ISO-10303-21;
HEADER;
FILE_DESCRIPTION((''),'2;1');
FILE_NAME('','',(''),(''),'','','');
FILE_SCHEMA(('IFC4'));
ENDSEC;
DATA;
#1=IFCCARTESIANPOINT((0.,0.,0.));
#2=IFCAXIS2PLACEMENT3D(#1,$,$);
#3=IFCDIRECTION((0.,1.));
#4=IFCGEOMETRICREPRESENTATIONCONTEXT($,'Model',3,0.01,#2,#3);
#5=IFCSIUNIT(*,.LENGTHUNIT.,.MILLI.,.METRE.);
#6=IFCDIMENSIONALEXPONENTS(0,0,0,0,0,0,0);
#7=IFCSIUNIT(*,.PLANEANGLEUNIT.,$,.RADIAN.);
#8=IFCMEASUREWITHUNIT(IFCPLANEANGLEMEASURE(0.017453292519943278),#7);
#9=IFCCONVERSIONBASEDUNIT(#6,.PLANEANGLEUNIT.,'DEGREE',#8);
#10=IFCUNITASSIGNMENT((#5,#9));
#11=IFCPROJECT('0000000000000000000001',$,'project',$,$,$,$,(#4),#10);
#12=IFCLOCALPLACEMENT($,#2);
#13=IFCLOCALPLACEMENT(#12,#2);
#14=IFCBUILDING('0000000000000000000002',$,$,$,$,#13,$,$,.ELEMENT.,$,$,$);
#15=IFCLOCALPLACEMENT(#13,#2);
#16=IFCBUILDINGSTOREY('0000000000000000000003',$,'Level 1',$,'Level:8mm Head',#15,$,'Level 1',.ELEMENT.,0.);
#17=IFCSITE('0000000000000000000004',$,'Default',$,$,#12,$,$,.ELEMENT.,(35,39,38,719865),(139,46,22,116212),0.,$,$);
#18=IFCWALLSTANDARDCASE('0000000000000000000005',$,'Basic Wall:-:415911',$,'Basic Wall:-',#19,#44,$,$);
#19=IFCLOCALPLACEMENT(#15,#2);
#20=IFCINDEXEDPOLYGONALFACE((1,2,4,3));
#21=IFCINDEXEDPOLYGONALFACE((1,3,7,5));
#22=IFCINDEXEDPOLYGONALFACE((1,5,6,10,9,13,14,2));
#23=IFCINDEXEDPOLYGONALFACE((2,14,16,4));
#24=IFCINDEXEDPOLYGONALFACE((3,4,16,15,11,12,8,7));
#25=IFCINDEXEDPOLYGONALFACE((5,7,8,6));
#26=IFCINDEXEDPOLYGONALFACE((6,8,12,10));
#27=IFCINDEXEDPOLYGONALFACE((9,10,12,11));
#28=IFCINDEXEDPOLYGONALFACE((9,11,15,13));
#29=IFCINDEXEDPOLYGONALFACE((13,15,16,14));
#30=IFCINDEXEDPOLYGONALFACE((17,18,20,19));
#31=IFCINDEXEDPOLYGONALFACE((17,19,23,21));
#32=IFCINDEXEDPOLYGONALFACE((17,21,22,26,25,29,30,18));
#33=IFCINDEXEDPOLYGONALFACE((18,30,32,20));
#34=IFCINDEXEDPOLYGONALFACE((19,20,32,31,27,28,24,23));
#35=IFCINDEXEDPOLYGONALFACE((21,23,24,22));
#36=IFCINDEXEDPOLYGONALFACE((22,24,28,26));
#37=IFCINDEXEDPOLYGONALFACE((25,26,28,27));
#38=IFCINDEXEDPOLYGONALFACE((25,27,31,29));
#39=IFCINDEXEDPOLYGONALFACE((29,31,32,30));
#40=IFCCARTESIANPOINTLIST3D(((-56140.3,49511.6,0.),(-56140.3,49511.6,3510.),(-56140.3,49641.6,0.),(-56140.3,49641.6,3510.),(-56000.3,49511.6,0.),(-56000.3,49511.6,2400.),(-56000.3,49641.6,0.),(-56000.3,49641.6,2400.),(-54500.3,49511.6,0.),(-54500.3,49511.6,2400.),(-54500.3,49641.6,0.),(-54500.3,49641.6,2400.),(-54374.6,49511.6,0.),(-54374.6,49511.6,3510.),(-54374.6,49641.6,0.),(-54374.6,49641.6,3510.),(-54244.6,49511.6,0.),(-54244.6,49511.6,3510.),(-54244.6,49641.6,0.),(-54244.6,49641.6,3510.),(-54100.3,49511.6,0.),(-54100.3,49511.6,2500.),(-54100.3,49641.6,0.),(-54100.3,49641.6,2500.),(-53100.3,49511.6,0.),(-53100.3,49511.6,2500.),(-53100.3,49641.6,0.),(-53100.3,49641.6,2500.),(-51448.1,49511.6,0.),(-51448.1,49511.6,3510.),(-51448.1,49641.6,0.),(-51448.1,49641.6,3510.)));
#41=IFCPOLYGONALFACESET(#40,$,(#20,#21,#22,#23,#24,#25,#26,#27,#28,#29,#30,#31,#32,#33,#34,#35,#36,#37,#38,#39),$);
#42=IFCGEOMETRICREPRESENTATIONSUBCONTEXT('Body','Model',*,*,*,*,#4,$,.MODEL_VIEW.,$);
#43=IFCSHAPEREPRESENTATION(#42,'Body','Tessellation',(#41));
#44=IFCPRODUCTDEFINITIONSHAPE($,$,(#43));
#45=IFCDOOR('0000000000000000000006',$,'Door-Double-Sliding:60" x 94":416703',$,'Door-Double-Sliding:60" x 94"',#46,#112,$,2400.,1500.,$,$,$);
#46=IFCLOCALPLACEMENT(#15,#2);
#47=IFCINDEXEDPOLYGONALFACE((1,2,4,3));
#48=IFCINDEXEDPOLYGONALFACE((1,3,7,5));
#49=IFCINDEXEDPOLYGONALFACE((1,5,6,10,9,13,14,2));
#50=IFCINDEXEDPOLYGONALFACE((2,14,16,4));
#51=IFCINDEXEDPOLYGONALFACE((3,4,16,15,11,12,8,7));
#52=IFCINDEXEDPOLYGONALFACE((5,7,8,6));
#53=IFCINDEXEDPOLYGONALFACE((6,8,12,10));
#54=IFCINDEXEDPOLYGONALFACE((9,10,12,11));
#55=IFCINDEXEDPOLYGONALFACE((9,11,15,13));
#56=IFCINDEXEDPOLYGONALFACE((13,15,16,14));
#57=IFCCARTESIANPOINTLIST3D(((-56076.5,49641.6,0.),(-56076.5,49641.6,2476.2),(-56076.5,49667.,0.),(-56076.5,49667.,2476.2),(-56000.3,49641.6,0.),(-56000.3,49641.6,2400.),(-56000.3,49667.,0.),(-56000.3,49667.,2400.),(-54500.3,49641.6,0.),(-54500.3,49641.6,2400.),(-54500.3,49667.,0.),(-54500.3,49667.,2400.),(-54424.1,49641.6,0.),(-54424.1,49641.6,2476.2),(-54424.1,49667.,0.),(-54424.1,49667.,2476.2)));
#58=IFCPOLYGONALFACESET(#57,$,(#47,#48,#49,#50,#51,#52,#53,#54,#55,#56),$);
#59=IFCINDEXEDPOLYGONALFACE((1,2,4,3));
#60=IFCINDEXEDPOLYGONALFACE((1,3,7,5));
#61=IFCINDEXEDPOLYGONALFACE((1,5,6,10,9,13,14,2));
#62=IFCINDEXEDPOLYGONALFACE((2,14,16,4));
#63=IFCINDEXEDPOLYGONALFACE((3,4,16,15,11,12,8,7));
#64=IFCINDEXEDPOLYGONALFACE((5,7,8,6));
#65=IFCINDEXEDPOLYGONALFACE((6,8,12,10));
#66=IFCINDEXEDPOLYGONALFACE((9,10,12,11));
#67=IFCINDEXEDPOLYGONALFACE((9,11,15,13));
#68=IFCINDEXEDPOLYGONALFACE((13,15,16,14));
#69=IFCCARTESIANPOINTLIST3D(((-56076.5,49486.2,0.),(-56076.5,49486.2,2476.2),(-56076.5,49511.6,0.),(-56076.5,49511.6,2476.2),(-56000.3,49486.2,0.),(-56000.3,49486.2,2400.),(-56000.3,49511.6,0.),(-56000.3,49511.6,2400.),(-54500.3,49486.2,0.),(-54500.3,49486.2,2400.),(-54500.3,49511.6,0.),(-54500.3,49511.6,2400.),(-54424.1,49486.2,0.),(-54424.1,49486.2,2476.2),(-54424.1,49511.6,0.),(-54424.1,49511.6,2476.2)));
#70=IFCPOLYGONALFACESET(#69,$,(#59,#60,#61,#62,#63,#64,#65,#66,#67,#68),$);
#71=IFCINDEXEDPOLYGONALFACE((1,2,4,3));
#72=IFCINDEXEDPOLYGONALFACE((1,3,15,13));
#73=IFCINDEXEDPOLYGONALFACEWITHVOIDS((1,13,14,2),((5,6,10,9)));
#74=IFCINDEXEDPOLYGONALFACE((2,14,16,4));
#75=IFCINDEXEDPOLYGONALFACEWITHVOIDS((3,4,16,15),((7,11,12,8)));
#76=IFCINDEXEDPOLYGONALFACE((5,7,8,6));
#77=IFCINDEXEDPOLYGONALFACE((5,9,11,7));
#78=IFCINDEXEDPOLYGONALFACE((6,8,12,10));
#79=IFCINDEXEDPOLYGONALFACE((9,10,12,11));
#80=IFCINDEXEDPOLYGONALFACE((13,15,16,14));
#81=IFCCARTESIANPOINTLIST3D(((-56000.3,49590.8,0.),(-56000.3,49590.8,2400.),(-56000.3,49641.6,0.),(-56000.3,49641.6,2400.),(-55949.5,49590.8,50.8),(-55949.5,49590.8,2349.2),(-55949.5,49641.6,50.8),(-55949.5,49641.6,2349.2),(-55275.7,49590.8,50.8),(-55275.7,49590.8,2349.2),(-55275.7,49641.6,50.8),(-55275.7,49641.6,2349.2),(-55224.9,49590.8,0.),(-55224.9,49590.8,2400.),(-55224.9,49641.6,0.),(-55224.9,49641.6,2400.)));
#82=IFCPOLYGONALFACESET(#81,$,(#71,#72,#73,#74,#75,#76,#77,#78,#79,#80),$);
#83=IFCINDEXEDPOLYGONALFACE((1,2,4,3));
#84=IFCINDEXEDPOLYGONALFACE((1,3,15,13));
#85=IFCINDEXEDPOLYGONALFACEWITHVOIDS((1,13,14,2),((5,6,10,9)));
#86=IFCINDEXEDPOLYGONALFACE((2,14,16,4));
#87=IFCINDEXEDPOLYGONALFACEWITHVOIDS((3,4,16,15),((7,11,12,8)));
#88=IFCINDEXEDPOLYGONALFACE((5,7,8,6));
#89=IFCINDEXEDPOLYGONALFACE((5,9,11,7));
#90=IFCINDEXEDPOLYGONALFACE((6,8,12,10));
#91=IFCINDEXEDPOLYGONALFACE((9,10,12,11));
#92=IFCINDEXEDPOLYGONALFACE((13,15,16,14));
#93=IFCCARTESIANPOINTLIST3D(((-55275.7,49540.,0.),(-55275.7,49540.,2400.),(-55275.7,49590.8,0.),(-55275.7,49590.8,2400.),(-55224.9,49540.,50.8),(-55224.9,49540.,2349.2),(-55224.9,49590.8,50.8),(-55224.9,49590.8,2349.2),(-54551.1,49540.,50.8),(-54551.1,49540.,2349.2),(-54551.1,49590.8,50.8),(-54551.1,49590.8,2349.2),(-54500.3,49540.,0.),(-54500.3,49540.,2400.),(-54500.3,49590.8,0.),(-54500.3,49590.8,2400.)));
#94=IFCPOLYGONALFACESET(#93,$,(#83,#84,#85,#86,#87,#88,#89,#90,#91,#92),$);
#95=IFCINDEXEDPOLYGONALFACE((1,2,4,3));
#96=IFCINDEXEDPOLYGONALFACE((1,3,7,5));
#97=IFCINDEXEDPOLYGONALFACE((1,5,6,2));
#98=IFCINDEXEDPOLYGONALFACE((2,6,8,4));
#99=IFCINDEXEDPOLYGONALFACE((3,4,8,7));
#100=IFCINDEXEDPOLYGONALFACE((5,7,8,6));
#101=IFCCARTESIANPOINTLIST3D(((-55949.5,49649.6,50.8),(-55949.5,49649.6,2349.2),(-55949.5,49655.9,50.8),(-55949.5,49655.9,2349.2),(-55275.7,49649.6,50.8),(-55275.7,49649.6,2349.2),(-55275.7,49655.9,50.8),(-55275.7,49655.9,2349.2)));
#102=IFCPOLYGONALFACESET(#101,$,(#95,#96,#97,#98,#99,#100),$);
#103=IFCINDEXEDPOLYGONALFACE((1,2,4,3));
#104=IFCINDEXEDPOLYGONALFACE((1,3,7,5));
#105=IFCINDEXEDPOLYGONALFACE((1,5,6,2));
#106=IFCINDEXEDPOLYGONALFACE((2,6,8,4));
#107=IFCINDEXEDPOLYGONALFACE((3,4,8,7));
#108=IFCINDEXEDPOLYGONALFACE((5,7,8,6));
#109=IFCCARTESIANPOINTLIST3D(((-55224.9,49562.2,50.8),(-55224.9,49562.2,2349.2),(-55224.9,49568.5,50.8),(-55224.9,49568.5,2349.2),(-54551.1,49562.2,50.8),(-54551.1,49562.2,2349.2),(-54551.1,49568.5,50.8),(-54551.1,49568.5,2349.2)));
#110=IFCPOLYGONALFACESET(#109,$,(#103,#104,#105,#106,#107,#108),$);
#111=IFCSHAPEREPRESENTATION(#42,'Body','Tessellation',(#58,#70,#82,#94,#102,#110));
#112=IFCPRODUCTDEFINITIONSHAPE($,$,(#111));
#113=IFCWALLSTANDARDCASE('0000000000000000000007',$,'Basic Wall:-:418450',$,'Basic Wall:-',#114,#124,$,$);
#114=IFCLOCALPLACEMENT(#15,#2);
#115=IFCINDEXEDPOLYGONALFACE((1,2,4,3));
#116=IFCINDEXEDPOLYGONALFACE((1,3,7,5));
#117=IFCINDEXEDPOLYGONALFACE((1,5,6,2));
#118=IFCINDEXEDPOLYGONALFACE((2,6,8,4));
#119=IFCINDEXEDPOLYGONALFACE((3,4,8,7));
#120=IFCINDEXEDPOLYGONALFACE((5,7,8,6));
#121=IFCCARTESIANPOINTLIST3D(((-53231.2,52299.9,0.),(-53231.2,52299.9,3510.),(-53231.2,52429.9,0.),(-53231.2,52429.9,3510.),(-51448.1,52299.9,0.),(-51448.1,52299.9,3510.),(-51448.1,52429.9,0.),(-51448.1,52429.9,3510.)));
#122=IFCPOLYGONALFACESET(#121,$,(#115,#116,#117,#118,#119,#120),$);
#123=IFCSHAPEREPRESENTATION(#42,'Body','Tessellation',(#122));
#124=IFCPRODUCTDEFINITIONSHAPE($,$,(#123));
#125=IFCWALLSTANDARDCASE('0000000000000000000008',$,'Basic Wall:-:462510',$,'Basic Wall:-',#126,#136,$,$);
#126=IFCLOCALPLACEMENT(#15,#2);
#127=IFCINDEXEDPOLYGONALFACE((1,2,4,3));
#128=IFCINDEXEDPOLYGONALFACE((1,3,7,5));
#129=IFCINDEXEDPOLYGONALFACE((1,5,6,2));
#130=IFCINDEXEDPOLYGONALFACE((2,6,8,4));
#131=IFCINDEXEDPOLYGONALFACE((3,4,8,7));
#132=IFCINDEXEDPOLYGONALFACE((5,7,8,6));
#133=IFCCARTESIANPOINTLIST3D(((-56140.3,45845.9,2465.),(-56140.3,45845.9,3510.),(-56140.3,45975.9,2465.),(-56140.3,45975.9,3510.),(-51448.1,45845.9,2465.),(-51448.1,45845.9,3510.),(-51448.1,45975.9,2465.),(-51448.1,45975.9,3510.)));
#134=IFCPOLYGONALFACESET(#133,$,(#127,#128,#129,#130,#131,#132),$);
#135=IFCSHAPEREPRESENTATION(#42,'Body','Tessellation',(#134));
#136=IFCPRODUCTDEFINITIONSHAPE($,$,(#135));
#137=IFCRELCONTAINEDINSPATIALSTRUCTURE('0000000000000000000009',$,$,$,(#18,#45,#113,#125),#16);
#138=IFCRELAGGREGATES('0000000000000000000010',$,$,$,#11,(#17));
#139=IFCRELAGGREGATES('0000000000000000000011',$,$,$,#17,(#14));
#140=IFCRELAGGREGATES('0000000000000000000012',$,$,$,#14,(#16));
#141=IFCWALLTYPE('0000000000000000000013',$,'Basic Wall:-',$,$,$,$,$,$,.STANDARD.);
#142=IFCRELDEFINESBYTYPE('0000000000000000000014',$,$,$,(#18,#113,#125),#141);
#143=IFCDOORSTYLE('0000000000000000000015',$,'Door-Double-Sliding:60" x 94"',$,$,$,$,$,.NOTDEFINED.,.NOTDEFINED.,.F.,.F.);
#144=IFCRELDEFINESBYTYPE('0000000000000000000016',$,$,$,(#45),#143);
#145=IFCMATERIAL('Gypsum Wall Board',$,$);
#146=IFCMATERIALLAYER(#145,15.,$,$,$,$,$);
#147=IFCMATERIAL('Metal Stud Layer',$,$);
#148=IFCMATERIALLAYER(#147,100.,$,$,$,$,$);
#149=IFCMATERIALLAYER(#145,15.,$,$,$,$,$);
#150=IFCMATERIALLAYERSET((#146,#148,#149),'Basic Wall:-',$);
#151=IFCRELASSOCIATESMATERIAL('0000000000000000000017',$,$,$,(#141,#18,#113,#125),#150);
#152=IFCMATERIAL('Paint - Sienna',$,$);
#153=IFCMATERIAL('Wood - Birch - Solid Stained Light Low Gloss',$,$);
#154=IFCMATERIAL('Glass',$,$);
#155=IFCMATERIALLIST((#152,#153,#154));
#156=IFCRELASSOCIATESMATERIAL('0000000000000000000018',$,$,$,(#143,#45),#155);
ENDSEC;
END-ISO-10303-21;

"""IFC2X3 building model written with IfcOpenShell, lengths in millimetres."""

from ifc_helpers import new_model, entity, si_unit, converted_unit, direction, frame, frame_2d, origin, origin_2d_with_axis, place, context, subcontext, project, spatial, polyline, rectangle, outline, extrude, source, transform, mapped, material, material_list, layer, layer_set, layer_usage, type_object, type_shapes, element, fill, save


model = new_model("IFC2X3")

# Units and contexts
model_context = context("Model", 3, precision=0.01, world=origin(), true_north=direction((0.0, 1.0)))
body_context = subcontext(model_context, "Body", "Model", "MODEL_VIEW")
ifc_project = project(units=[si_unit("LENGTHUNIT", "METRE", prefix="MILLI"), converted_unit("PLANEANGLEUNIT", "DEGREE", entity("IfcPlaneAngleMeasure", 0.017453292519943278), si_unit("PLANEANGLEUNIT", "RADIAN"), dimensions=[0, 0, 0, 0, 0, 0, 0])], contexts=[model_context])

# Site, building, storey
site_placement = place(None, origin())
site = spatial("IfcSite", under=ifc_project, at=site_placement, Name="Default", CompositionType="ELEMENT", RefLatitude=(35, 39, 38, 719865), RefLongitude=(139, 46, 22, 116212), RefElevation=0.0)
building_placement = place(site_placement, origin())
building = spatial("IfcBuilding", under=site, at=building_placement, CompositionType="ELEMENT")
storey_placement = place(building_placement, origin())
storey = spatial("IfcBuildingStorey", under=building, at=storey_placement, Name="Level 1", ObjectType="Level:8mm Head", LongName="Level 1", CompositionType="ELEMENT", Elevation=0.0)

# Shared definitions
ifc_material_1 = material(Name="Glass")

# Wall, openings, door
ifc_material_2 = material(Name="Gypsum Wall Board")
ifc_layer_1 = layer(ifc_material_2, 15.0)
ifc_material_3 = material(Name="Metal Stud Layer")
ifc_layer_2 = layer(ifc_material_3, 100.0)
ifc_layer_3 = layer(ifc_material_2, 15.0)
ifc_layer_set_1 = layer_set([ifc_layer_1, ifc_layer_2, ifc_layer_3], Name="Basic Wall:-")
ifc_layer_usage_1 = layer_usage(ifc_layer_set_1, "AXIS2", "NEGATIVE", 65.0)
wall_type = type_object("IfcWallType", Name="Basic Wall:-", PredefinedType="STANDARD", material=ifc_layer_set_1)
wall_1_placement = place(storey_placement, frame((-51448.1, 49576.6, 0.0), z_axis=(0.0, 0.0, 1.0), x_axis=(-1.0, 0.0, 0.0)))
wall_1 = element("IfcWallStandardCase", 1, at=wall_1_placement, inside=storey, type_object=wall_type, material=ifc_layer_usage_1, Name="Basic Wall:-:415911", ObjectType="Basic Wall:-", context=body_context, shape_type="SweptSolid", body=[
    extrude(rectangle(XDim=4692.1, YDim=130.0, at=frame_2d((2346.1, 0.0), x_axis=(-1.0, 0.0))), origin(), (0.0, 0.0, 1.0), 3510.0),
])
opening_1_placement = place(storey_placement, frame((-51448.1, 49576.6, 0.0), z_axis=(0.0, 0.0, 1.0), x_axis=(-1.0, 0.0, 0.0)))
element("IfcOpeningElement", 2, at=opening_1_placement, cuts=wall_1, ObjectType="Opening", context=body_context, shape_type="SweptSolid", body=[
    extrude(rectangle(XDim=3510.0, YDim=130.0, at=frame_2d((0.0, 0.0), x_axis=(1.0, 0.0))), frame((2926.4, 0.0, 1755.0), z_axis=(-1.0, 0.0, 0.0), x_axis=(0.0, 0.0, 1.0)), (0.0, 0.0, 1.0), 130.0),
])
opening_2_placement = place(wall_1_placement, frame((4552.1, 65.0, 0.0)))
opening_2 = element("IfcOpeningElement", 3, at=opening_2_placement, cuts=wall_1, ObjectType="Opening", context=body_context, shape_type="SweptSolid", body=[
    extrude(rectangle(XDim=2400.0, YDim=1500.0, at=frame_2d((1200.0, 750.0), x_axis=(-1.0, 0.0))), frame((0.0, 0.0, 0.0), z_axis=(0.0, -1.0, 0.0), x_axis=(0.0, 0.0, 1.0)), (0.0, 0.0, 1.0), 130.0),
])
opening_3_placement = place(wall_1_placement, frame((-51448.1, 49576.6, 0.0), z_axis=(0.0, 0.0, 1.0), x_axis=(-1.0, 0.0, 0.0)))
element("IfcOpeningElement", 4, at=opening_3_placement, cuts=wall_1, ObjectType="Opening", context=body_context, shape_type="SweptSolid", body=[
    extrude(rectangle(XDim=2500.0, YDim=1000.0, at=origin_2d_with_axis()), frame((-53600.3, 51035.6, 1250.0), z_axis=(0.0, -1.0, 0.0), x_axis=(0.0, 0.0, 1.0)), (0.0, 0.0, 1.0), 3048.0),
])
ifc_material_4 = material(Name="Paint - Sienna")
ifc_material_5 = material(Name="Wood - Birch - Solid Stained Light Low Gloss")
ifc_material_list_1 = material_list([ifc_material_4, ifc_material_5, ifc_material_1])
door_style_1 = type_object("IfcDoorStyle", Name="Door-Double-Sliding:60\" x 94\"", ConstructionType="NOTDEFINED", OperationType="NOTDEFINED", ParameterTakesPrecedence=False, Sizeable=False, material=ifc_material_list_1)
shared_shape_1 = source(origin(), body_context, "Body", "SweptSolid", [
    extrude(outline(polyline([(-826.2, -1219.0), (-750.0, -1219.0), (-750.0, 1181.0), (750.0, 1180.9), (750.0, -1219.1), (826.2, -1219.1), (826.2, 1257.1), (-826.2, 1257.1), (-826.2, -1219.0)])), frame((750.0, 130.0, 1219.0), z_axis=(0.0, 1.0, 0.0), x_axis=(-1.0, 0.0, 0.0)), (0.0, 0.0, 1.0), 25.4),
    extrude(outline(polyline([(-1219.0, -826.2), (1257.1, -826.2), (1257.1, 826.2), (-1219.0, 826.2), (-1219.0, 750.0), (1180.9, 750.0), (1180.9, -750.0), (-1219.0, -750.0), (-1219.0, -826.2)])), frame((750.0, -25.4, 1219.0), z_axis=(0.0, 1.0, 0.0), x_axis=(0.0, 0.0, 1.0)), (0.0, 0.0, 1.0), 25.4),
    extrude(outline(polyline([(-1200.0, -387.7), (1200.0, -387.7), (1200.0, 387.7), (-1200.0, 387.7), (-1200.0, -387.7)]), holes=[polyline([(-1149.2, -336.9), (-1149.2, 336.9), (1149.2, 336.9), (1149.2, -336.9), (-1149.2, -336.9)])]), frame((387.7, 79.2, 1200.0), z_axis=(0.0, 1.0, 0.0), x_axis=(0.0, 0.0, -1.0)), (0.0, 0.0, 1.0), 50.8),
    extrude(outline(polyline([(-387.7, -1200.0), (387.7, -1200.0), (387.7, 1200.0), (-387.7, 1200.0), (-387.7, -1200.0)]), holes=[polyline([(-336.9, -1149.2), (-336.9, 1149.2), (336.9, 1149.2), (336.9, -1149.2), (-336.9, -1149.2)])]), frame((1112.3, 28.4, 1200.0), z_axis=(0.0, 1.0, 0.0), x_axis=(1.0, 0.0, 0.0)), (0.0, 0.0, 1.0), 50.8),
    extrude(rectangle(XDim=6.4, YDim=673.8, at=origin_2d_with_axis()), frame((387.7, 141.2, 50.8), z_axis=(0.0, 0.0, 1.0), x_axis=(0.0, 1.0, 0.0)), (0.0, 0.0, 1.0), 2298.4),
    extrude(rectangle(XDim=6.3, YDim=673.8, at=frame_2d((0.0, 0.0), x_axis=(1.0, 0.0))), frame((1112.3, 53.8, 50.8), z_axis=(0.0, 0.0, 1.0), x_axis=(0.0, -1.0, 0.0)), (0.0, 0.0, 1.0), 2298.4),
])
type_shapes(door_style_1, [shared_shape_1])
door_1_placement = place(opening_2_placement, frame((0.0, 0.0, 0.0), z_axis=(0.0, 0.0, 1.0), x_axis=(-1.0, 0.0, 0.0)))
door_1 = element("IfcDoor", 5, at=door_1_placement, inside=storey, type_object=door_style_1, material=ifc_material_list_1, Name="Door-Double-Sliding:60\" x 94\":416703", ObjectType="Door-Double-Sliding:60\" x 94\"", OverallHeight=2400.0, OverallWidth=1500.0, context=body_context, shape_type="MappedRepresentation", body=[
    mapped(shared_shape_1, transform((0.0, 0.0, 0.0), scale=1.0)),
])
fill(opening_2, door_1)

# Walls
ifc_layer_usage_2 = layer_usage(ifc_layer_set_1, "AXIS2", "NEGATIVE", 65.0)
wall_2_placement = place(storey_placement, frame((-51448.1, 52364.9, 0.0), z_axis=(0.0, 0.0, 1.0), x_axis=(-1.0, 0.0, 0.0)))
element("IfcWallStandardCase", 6, at=wall_2_placement, inside=storey, type_object=wall_type, material=ifc_layer_usage_2, Name="Basic Wall:-:418450", ObjectType="Basic Wall:-", context=body_context, shape_type="SweptSolid", body=[
    extrude(rectangle(XDim=1783.1, YDim=130.0, at=frame_2d((891.5, 0.0), x_axis=(-1.0, 0.0))), origin(), (0.0, 0.0, 1.0), 3510.0),
])
ifc_layer_usage_3 = layer_usage(ifc_layer_set_1, "AXIS2", "NEGATIVE", 65.0)
wall_3_placement = place(storey_placement, frame((-51448.1, 45910.9, 2465.0), z_axis=(0.0, 0.0, 1.0), x_axis=(-1.0, 0.0, 0.0)))
element("IfcWallStandardCase", 7, at=wall_3_placement, inside=storey, type_object=wall_type, material=ifc_layer_usage_3, Name="Basic Wall:-:462510", ObjectType="Basic Wall:-", context=body_context, shape_type="SweptSolid", body=[
    extrude(rectangle(XDim=4692.1, YDim=130.0, at=frame_2d((2346.1, 0.0), x_axis=(-1.0, 0.0))), origin(), (0.0, 0.0, 1.0), 1045.0),
])

save(model, "model.ifc")
